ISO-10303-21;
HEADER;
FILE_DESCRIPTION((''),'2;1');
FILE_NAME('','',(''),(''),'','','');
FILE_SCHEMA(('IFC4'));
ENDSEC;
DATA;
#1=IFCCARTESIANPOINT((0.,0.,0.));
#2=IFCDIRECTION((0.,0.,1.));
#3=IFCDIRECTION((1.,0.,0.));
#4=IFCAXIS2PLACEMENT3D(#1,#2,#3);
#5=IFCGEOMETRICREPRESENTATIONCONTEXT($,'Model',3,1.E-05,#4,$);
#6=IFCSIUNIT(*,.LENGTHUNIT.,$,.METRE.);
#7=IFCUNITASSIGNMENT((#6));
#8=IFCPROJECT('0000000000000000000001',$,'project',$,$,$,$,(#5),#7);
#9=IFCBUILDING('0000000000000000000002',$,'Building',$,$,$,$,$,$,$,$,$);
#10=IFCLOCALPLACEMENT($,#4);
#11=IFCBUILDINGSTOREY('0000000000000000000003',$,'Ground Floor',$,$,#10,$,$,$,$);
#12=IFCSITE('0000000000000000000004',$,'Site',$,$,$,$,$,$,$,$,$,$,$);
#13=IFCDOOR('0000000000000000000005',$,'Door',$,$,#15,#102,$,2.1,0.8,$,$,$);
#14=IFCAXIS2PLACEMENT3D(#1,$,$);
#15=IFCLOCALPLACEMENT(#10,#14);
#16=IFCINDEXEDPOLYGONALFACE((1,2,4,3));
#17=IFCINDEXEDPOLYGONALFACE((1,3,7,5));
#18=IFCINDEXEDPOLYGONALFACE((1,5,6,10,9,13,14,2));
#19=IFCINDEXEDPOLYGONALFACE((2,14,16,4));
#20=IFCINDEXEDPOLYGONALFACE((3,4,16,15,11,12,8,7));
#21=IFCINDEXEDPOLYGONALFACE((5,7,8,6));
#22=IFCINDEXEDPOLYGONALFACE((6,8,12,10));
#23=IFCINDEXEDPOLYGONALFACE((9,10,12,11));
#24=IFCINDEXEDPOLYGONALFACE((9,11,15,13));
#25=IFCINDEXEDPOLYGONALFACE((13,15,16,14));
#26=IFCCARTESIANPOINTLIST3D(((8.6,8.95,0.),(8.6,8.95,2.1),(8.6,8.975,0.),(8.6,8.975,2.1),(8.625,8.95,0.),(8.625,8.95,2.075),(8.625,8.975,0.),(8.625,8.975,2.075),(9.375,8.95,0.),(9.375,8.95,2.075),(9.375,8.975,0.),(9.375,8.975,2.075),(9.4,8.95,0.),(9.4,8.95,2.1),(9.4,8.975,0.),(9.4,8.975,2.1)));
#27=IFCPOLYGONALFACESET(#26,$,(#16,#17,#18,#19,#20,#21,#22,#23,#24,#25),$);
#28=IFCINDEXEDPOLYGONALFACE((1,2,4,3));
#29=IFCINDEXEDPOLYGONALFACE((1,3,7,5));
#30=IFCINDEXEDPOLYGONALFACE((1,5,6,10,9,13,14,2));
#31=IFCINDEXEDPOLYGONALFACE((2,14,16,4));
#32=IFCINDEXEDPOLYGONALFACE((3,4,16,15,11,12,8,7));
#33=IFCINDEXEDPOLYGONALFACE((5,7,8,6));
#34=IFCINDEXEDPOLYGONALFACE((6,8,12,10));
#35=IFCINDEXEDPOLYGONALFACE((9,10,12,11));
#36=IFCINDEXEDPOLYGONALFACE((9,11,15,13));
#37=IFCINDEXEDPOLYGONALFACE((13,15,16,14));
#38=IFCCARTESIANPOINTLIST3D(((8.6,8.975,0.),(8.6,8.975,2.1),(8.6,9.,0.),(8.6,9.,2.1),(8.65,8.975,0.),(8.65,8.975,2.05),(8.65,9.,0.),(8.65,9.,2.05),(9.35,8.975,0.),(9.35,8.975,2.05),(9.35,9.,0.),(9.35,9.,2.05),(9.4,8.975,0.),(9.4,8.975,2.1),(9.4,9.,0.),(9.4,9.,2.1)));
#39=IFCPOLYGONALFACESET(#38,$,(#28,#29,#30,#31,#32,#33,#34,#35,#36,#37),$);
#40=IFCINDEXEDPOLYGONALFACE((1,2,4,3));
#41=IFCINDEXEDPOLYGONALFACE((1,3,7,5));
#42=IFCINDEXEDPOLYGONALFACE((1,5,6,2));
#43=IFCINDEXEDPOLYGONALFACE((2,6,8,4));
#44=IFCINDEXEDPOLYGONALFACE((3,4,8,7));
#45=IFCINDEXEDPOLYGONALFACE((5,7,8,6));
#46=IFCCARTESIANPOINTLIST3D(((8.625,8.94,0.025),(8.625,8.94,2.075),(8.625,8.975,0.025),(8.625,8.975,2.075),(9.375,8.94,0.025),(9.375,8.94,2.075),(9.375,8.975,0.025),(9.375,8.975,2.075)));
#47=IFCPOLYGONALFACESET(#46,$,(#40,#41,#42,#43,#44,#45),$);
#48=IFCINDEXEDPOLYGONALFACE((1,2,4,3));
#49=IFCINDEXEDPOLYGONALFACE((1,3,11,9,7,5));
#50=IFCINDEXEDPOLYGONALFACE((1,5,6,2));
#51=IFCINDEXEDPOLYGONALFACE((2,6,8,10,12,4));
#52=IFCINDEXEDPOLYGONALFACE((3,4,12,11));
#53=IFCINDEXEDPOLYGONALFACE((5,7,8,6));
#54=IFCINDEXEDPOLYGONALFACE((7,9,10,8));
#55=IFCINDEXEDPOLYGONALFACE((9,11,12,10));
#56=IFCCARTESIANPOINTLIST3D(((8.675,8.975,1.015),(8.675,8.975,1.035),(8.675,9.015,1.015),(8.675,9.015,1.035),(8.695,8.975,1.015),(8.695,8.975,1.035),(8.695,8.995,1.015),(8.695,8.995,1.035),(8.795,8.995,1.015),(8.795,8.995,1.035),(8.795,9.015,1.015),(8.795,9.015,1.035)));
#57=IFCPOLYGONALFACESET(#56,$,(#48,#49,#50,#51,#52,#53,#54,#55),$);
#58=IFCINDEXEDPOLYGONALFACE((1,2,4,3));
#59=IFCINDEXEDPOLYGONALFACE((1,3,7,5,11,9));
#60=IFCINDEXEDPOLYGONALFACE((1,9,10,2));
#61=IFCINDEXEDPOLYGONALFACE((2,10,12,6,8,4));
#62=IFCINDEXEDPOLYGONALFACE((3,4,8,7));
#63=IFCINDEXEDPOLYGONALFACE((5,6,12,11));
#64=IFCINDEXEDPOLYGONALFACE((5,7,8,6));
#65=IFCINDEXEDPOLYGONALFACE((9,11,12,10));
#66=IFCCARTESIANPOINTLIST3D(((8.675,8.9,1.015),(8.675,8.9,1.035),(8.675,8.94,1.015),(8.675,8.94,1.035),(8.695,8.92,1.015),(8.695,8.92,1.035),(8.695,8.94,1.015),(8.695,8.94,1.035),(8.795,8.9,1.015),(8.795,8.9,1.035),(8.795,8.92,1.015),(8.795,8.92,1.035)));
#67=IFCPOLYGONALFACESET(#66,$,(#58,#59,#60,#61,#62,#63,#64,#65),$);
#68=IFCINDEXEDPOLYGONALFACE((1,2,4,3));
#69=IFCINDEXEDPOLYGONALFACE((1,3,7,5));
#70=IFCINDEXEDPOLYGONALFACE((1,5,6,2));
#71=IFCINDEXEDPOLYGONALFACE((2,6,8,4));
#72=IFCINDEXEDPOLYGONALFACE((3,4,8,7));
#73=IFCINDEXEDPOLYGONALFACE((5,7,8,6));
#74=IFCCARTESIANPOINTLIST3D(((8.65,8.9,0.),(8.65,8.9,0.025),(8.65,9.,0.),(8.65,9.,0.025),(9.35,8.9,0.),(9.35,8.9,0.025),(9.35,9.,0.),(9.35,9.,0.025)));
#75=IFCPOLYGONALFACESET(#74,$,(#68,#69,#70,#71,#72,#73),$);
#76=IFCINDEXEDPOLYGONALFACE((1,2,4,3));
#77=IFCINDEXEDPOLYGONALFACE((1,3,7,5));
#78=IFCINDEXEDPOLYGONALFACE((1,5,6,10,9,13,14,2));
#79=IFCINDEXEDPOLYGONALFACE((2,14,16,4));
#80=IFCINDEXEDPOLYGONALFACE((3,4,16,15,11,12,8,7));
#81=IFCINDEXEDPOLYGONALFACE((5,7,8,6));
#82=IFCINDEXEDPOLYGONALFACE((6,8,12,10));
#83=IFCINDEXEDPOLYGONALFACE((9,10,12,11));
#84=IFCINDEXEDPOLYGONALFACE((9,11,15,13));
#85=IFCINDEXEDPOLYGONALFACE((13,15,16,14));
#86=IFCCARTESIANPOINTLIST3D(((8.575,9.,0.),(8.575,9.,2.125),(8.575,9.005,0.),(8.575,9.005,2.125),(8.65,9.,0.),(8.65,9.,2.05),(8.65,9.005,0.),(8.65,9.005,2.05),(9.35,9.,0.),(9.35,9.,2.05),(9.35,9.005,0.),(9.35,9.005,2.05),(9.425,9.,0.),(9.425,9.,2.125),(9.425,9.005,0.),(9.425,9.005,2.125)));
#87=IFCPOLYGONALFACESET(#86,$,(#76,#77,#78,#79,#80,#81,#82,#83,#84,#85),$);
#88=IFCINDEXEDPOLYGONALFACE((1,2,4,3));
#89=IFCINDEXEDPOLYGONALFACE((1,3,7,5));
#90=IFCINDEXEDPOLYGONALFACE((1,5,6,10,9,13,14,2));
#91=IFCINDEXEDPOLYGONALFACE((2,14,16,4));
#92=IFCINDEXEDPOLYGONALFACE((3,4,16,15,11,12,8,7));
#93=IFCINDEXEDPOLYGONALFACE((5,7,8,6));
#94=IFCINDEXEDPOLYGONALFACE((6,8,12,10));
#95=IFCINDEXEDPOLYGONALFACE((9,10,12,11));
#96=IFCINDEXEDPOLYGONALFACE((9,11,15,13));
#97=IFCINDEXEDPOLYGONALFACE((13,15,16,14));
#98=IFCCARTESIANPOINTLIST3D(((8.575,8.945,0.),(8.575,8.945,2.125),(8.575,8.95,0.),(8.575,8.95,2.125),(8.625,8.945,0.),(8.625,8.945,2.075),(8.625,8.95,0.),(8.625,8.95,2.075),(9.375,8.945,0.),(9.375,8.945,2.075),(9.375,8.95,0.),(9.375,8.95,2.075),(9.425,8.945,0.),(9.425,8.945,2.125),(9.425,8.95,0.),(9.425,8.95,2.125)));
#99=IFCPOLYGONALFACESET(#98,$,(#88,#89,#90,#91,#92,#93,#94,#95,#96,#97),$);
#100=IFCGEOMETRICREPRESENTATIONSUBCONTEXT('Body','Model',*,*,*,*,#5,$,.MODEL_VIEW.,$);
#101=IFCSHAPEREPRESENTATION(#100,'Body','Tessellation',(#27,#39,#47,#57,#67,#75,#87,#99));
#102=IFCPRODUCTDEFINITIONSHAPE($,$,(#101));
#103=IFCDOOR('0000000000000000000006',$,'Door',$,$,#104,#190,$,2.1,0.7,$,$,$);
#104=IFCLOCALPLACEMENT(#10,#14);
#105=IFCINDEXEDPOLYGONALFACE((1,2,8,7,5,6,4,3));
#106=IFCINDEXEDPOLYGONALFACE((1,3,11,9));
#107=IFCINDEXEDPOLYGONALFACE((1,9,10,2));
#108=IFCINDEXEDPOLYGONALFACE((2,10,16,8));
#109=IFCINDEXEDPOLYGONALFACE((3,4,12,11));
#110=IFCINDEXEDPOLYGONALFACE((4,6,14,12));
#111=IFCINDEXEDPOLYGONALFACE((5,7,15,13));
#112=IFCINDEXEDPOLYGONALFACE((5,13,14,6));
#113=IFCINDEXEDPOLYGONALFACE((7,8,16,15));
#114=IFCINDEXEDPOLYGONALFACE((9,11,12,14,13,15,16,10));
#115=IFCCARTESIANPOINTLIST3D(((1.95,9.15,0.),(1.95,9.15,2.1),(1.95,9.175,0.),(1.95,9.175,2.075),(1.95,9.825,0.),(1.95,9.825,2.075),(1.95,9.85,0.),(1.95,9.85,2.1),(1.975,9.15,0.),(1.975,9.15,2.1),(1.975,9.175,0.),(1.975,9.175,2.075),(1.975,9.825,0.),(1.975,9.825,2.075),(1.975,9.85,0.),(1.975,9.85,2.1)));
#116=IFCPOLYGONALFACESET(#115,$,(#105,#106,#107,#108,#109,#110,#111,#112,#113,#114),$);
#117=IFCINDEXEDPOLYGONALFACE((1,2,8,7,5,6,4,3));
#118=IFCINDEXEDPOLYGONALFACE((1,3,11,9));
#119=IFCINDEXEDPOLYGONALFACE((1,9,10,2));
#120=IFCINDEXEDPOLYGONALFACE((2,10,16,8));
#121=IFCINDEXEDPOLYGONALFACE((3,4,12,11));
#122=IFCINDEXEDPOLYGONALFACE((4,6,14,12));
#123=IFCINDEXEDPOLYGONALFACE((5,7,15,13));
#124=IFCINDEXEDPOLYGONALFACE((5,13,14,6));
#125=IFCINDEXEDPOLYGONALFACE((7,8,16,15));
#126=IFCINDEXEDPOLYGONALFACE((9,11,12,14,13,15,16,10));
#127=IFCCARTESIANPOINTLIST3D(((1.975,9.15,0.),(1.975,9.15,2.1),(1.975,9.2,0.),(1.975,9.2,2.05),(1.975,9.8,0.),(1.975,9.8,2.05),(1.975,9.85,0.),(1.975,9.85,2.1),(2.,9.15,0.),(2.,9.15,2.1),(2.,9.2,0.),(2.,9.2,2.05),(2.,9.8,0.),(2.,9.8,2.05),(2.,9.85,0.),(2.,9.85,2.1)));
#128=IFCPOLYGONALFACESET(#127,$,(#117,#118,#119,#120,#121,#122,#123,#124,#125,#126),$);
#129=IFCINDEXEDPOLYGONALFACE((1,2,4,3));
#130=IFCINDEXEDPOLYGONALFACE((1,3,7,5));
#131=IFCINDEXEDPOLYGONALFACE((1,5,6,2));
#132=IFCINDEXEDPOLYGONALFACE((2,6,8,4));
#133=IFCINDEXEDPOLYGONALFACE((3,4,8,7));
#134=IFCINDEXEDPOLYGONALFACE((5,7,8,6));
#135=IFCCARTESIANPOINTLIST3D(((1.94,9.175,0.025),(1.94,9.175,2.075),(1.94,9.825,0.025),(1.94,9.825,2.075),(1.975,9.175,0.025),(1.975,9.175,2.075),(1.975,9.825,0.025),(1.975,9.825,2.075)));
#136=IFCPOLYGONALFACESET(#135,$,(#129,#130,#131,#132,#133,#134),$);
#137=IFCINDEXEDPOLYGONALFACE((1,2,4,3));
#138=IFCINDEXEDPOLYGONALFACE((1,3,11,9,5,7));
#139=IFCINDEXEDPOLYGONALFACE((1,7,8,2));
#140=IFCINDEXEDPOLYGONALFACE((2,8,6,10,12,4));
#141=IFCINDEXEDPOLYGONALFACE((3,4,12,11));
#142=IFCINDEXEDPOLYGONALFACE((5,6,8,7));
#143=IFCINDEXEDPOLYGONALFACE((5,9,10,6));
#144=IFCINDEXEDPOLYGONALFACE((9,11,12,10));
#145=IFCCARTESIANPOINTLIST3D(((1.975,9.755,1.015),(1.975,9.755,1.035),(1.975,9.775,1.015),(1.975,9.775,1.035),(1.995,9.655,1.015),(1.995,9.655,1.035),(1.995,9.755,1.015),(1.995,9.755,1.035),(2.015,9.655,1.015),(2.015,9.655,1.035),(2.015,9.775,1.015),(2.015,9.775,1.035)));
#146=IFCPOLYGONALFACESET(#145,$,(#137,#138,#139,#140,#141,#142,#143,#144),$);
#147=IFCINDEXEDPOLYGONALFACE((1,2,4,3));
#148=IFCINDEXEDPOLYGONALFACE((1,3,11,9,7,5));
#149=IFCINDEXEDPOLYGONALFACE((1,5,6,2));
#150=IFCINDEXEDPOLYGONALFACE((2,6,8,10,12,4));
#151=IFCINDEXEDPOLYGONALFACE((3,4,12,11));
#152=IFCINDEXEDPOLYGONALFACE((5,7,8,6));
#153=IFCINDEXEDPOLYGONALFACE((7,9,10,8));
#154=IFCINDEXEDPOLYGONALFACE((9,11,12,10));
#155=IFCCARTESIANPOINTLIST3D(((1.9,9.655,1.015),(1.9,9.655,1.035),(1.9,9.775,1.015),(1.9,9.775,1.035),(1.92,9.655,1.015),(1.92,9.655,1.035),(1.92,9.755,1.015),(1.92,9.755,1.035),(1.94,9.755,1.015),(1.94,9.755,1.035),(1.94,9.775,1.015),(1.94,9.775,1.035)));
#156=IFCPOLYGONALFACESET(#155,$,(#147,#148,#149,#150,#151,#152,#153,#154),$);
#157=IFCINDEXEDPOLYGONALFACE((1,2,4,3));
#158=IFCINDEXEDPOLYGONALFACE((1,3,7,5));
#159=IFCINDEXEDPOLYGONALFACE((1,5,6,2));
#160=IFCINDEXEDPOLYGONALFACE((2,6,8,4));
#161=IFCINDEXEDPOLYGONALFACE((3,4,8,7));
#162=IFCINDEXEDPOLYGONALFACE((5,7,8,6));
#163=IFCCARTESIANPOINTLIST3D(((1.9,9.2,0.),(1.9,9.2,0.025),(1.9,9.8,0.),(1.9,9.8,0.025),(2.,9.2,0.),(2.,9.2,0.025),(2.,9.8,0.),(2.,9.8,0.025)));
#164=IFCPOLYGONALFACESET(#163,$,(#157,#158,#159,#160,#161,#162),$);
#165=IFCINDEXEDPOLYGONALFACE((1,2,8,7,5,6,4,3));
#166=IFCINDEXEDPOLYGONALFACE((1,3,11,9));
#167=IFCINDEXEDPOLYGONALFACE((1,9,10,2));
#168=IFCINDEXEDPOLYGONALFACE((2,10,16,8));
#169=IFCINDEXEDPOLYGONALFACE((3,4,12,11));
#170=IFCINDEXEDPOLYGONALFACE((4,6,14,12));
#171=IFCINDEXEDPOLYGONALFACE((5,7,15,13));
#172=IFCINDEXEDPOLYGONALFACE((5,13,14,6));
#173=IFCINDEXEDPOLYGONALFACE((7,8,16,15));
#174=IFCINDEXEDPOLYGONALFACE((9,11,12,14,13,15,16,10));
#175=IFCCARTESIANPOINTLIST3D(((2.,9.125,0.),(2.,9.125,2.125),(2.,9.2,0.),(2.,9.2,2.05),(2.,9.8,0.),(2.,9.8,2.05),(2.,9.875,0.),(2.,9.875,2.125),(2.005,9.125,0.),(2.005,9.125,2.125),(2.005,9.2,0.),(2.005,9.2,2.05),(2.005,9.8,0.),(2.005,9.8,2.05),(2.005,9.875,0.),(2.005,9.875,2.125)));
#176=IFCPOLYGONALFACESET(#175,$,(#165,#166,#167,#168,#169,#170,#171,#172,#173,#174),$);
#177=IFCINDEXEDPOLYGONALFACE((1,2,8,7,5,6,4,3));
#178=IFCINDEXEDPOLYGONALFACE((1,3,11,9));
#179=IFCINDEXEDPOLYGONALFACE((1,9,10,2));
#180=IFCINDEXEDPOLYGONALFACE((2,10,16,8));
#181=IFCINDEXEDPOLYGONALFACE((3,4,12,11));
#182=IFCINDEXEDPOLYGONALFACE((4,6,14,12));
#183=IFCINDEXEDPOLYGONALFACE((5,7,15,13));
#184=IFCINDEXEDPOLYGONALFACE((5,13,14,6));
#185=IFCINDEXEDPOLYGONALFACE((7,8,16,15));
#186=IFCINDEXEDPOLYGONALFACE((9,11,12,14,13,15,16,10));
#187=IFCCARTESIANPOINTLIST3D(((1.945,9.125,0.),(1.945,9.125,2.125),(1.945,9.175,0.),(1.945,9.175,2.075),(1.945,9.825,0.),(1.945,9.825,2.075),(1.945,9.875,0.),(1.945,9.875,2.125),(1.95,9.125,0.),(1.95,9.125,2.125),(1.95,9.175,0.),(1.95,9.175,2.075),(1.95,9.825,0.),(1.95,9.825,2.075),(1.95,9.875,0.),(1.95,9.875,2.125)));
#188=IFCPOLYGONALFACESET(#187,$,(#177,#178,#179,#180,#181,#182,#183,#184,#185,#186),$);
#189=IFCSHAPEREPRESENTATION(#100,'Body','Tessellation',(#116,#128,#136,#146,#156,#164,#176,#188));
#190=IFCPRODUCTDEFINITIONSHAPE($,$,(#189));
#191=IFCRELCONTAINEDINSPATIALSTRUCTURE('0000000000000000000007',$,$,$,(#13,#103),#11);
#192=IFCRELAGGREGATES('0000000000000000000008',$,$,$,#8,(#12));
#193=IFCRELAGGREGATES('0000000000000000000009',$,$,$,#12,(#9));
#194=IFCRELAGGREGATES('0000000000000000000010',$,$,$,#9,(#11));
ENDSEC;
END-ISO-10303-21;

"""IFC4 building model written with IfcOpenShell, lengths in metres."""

from ifc_helpers import new_model, si_unit, frame, origin_with_axes, place, context, subcontext, project, spatial, line, indexed_curve, outline, extrude, element, save


model = new_model("IFC4")

# Units and contexts
model_context = context("Model", 3, precision=1e-05, world=origin_with_axes())
body_context = subcontext(model_context, "Body", "Model", "MODEL_VIEW")
ifc_project = project(units=[si_unit("LENGTHUNIT", "METRE")], contexts=[model_context])

# Site, building, storey
site = spatial("IfcSite", under=ifc_project, Name="Site")
building = spatial("IfcBuilding", under=site, Name="Building")
storey_placement = place(None, origin_with_axes())
storey = spatial("IfcBuildingStorey", under=building, at=storey_placement, Name="Ground Floor")

# Doors
door_1_placement = place(storey_placement, frame((9.4, 9.0, 0.0), z_axis=(0.0, 0.0, 1.0), x_axis=(-1.0, 0.0, 0.0)))
element("IfcDoor", 1, at=door_1_placement, inside=storey, Name="Door", OverallHeight=2.1, OverallWidth=0.8, context=body_context, shape_type="SweptSolid", body=[
    extrude(outline(indexed_curve([(0.0, 0.0), (0.0, 2.1), (0.8, 2.1), (0.8, 0.0), (0.775, 0.0), (0.775, 2.075), (0.025, 2.075), (0.025, 0.0)], segments=[line(1, 2, 3, 4, 5, 6, 7, 8, 1)])), frame((0.0, 0.025, 0.0), z_axis=(0.0, -1.0, 0.0), x_axis=(1.0, 0.0, 0.0)), (0.0, 0.0, -1.0), 0.025),
    extrude(outline(indexed_curve([(0.0, 0.0), (0.0, 2.1), (0.8, 2.1), (0.8, 0.0), (0.75, 0.0), (0.75, 2.05), (0.05, 2.05), (0.05, 0.0)], segments=[line(1, 2, 3, 4, 5, 6, 7, 8, 1)])), frame((0.0, 0.0, 0.0), z_axis=(0.0, -1.0, 0.0), x_axis=(1.0, 0.0, 0.0)), (0.0, 0.0, -1.0), 0.025),
    extrude(outline(indexed_curve([(0.0, 0.0), (0.75, 0.0), (0.75, 0.035), (0.0, 0.035)], segments=[line(1, 2, 3, 4, 1)])), frame((0.025, 0.025, 0.025), z_axis=(0.0, 0.0, 1.0), x_axis=(1.0, 0.0, 0.0)), (0.0, 0.0, 1.0), 2.05),
    extrude(outline(indexed_curve([(0.0, 0.0), (0.0, -0.04), (-0.12, -0.04), (-0.12, -0.02), (-0.02, -0.02), (-0.02, 0.0)], segments=[line(1, 2, 3, 4, 5, 6, 1)])), frame((0.725, 0.025, 1.015), z_axis=(0.0, 0.0, 1.0), x_axis=(1.0, 0.0, 0.0)), (0.0, 0.0, 1.0), 0.02),
    extrude(outline(indexed_curve([(0.0, 0.0), (0.0, 0.04), (-0.12, 0.04), (-0.12, 0.02), (-0.02, 0.02), (-0.02, 0.0)], segments=[line(1, 2, 3, 4, 5, 6, 1)])), frame((0.725, 0.06, 1.015), z_axis=(0.0, 0.0, 1.0), x_axis=(1.0, 0.0, 0.0)), (0.0, 0.0, 1.0), 0.02),
    extrude(outline(indexed_curve([(0.0, 0.0), (0.7, 0.0), (0.7, 0.1), (0.0, 0.1)], segments=[line(1, 2, 3, 4, 1)])), frame((0.05, 0.0, 0.0), z_axis=(0.0, 0.0, 1.0), x_axis=(1.0, 0.0, 0.0)), (0.0, 0.0, 1.0), 0.025),
    extrude(outline(indexed_curve([(0.0, 0.0), (0.0, 2.125), (0.85, 2.125), (0.85, 0.0), (0.775, 0.0), (0.775, 2.05), (0.075, 2.05), (0.075, 0.0)], segments=[line(1, 2, 3, 4, 5, 6, 7, 8, 1)])), frame((-0.025, -0.005, 0.0), z_axis=(0.0, -1.0, 0.0), x_axis=(1.0, 0.0, 0.0)), (0.0, 0.0, -1.0), 0.005),
    extrude(outline(indexed_curve([(0.0, 0.0), (0.0, 2.125), (0.85, 2.125), (0.85, 0.0), (0.8, 0.0), (0.8, 2.075), (0.05, 2.075), (0.05, 0.0)], segments=[line(1, 2, 3, 4, 5, 6, 7, 8, 1)])), frame((-0.025, 0.05, 0.0), z_axis=(0.0, -1.0, 0.0), x_axis=(1.0, 0.0, 0.0)), (0.0, 0.0, -1.0), 0.005),
])
door_2_placement = place(storey_placement, frame((2.0, 9.15, 0.0), z_axis=(0.0, 0.0, 1.0), x_axis=(0.0, 1.0, 0.0)))
element("IfcDoor", 2, at=door_2_placement, inside=storey, Name="Door", OverallHeight=2.1, OverallWidth=0.7, context=body_context, shape_type="SweptSolid", body=[
    extrude(outline(indexed_curve([(0.0, 0.0), (0.0, 2.1), (0.7, 2.1), (0.7, 0.0), (0.675, 0.0), (0.675, 2.075), (0.025, 2.075), (0.025, 0.0)], segments=[line(1, 2, 3, 4, 5, 6, 7, 8, 1)])), frame((0.0, 0.025, 0.0), z_axis=(0.0, -1.0, 0.0), x_axis=(1.0, 0.0, 0.0)), (0.0, 0.0, -1.0), 0.025),
    extrude(outline(indexed_curve([(0.0, 0.0), (0.0, 2.1), (0.7, 2.1), (0.7, 0.0), (0.65, 0.0), (0.65, 2.05), (0.05, 2.05), (0.05, 0.0)], segments=[line(1, 2, 3, 4, 5, 6, 7, 8, 1)])), frame((0.0, 0.0, 0.0), z_axis=(0.0, -1.0, 0.0), x_axis=(1.0, 0.0, 0.0)), (0.0, 0.0, -1.0), 0.025),
    extrude(outline(indexed_curve([(0.0, 0.0), (0.65, 0.0), (0.65, 0.035), (0.0, 0.035)], segments=[line(1, 2, 3, 4, 1)])), frame((0.025, 0.025, 0.025), z_axis=(0.0, 0.0, 1.0), x_axis=(1.0, 0.0, 0.0)), (0.0, 0.0, 1.0), 2.05),
    extrude(outline(indexed_curve([(0.0, 0.0), (0.0, -0.04), (-0.12, -0.04), (-0.12, -0.02), (-0.02, -0.02), (-0.02, 0.0)], segments=[line(1, 2, 3, 4, 5, 6, 1)])), frame((0.625, 0.025, 1.015), z_axis=(0.0, 0.0, 1.0), x_axis=(1.0, 0.0, 0.0)), (0.0, 0.0, 1.0), 0.02),
    extrude(outline(indexed_curve([(0.0, 0.0), (0.0, 0.04), (-0.12, 0.04), (-0.12, 0.02), (-0.02, 0.02), (-0.02, 0.0)], segments=[line(1, 2, 3, 4, 5, 6, 1)])), frame((0.625, 0.06, 1.015), z_axis=(0.0, 0.0, 1.0), x_axis=(1.0, 0.0, 0.0)), (0.0, 0.0, 1.0), 0.02),
    extrude(outline(indexed_curve([(0.0, 0.0), (0.6, 0.0), (0.6, 0.1), (0.0, 0.1)], segments=[line(1, 2, 3, 4, 1)])), frame((0.05, 0.0, 0.0), z_axis=(0.0, 0.0, 1.0), x_axis=(1.0, 0.0, 0.0)), (0.0, 0.0, 1.0), 0.025),
    extrude(outline(indexed_curve([(0.0, 0.0), (0.0, 2.125), (0.75, 2.125), (0.75, 0.0), (0.675, 0.0), (0.675, 2.05), (0.075, 2.05), (0.075, 0.0)], segments=[line(1, 2, 3, 4, 5, 6, 7, 8, 1)])), frame((-0.025, -0.005, 0.0), z_axis=(0.0, -1.0, 0.0), x_axis=(1.0, 0.0, 0.0)), (0.0, 0.0, -1.0), 0.005),
    extrude(outline(indexed_curve([(0.0, 0.0), (0.0, 2.125), (0.75, 2.125), (0.75, 0.0), (0.7, 0.0), (0.7, 2.075), (0.05, 2.075), (0.05, 0.0)], segments=[line(1, 2, 3, 4, 5, 6, 7, 8, 1)])), frame((-0.025, 0.05, 0.0), z_axis=(0.0, -1.0, 0.0), x_axis=(1.0, 0.0, 0.0)), (0.0, 0.0, -1.0), 0.005),
])

save(model, "model.ifc")
